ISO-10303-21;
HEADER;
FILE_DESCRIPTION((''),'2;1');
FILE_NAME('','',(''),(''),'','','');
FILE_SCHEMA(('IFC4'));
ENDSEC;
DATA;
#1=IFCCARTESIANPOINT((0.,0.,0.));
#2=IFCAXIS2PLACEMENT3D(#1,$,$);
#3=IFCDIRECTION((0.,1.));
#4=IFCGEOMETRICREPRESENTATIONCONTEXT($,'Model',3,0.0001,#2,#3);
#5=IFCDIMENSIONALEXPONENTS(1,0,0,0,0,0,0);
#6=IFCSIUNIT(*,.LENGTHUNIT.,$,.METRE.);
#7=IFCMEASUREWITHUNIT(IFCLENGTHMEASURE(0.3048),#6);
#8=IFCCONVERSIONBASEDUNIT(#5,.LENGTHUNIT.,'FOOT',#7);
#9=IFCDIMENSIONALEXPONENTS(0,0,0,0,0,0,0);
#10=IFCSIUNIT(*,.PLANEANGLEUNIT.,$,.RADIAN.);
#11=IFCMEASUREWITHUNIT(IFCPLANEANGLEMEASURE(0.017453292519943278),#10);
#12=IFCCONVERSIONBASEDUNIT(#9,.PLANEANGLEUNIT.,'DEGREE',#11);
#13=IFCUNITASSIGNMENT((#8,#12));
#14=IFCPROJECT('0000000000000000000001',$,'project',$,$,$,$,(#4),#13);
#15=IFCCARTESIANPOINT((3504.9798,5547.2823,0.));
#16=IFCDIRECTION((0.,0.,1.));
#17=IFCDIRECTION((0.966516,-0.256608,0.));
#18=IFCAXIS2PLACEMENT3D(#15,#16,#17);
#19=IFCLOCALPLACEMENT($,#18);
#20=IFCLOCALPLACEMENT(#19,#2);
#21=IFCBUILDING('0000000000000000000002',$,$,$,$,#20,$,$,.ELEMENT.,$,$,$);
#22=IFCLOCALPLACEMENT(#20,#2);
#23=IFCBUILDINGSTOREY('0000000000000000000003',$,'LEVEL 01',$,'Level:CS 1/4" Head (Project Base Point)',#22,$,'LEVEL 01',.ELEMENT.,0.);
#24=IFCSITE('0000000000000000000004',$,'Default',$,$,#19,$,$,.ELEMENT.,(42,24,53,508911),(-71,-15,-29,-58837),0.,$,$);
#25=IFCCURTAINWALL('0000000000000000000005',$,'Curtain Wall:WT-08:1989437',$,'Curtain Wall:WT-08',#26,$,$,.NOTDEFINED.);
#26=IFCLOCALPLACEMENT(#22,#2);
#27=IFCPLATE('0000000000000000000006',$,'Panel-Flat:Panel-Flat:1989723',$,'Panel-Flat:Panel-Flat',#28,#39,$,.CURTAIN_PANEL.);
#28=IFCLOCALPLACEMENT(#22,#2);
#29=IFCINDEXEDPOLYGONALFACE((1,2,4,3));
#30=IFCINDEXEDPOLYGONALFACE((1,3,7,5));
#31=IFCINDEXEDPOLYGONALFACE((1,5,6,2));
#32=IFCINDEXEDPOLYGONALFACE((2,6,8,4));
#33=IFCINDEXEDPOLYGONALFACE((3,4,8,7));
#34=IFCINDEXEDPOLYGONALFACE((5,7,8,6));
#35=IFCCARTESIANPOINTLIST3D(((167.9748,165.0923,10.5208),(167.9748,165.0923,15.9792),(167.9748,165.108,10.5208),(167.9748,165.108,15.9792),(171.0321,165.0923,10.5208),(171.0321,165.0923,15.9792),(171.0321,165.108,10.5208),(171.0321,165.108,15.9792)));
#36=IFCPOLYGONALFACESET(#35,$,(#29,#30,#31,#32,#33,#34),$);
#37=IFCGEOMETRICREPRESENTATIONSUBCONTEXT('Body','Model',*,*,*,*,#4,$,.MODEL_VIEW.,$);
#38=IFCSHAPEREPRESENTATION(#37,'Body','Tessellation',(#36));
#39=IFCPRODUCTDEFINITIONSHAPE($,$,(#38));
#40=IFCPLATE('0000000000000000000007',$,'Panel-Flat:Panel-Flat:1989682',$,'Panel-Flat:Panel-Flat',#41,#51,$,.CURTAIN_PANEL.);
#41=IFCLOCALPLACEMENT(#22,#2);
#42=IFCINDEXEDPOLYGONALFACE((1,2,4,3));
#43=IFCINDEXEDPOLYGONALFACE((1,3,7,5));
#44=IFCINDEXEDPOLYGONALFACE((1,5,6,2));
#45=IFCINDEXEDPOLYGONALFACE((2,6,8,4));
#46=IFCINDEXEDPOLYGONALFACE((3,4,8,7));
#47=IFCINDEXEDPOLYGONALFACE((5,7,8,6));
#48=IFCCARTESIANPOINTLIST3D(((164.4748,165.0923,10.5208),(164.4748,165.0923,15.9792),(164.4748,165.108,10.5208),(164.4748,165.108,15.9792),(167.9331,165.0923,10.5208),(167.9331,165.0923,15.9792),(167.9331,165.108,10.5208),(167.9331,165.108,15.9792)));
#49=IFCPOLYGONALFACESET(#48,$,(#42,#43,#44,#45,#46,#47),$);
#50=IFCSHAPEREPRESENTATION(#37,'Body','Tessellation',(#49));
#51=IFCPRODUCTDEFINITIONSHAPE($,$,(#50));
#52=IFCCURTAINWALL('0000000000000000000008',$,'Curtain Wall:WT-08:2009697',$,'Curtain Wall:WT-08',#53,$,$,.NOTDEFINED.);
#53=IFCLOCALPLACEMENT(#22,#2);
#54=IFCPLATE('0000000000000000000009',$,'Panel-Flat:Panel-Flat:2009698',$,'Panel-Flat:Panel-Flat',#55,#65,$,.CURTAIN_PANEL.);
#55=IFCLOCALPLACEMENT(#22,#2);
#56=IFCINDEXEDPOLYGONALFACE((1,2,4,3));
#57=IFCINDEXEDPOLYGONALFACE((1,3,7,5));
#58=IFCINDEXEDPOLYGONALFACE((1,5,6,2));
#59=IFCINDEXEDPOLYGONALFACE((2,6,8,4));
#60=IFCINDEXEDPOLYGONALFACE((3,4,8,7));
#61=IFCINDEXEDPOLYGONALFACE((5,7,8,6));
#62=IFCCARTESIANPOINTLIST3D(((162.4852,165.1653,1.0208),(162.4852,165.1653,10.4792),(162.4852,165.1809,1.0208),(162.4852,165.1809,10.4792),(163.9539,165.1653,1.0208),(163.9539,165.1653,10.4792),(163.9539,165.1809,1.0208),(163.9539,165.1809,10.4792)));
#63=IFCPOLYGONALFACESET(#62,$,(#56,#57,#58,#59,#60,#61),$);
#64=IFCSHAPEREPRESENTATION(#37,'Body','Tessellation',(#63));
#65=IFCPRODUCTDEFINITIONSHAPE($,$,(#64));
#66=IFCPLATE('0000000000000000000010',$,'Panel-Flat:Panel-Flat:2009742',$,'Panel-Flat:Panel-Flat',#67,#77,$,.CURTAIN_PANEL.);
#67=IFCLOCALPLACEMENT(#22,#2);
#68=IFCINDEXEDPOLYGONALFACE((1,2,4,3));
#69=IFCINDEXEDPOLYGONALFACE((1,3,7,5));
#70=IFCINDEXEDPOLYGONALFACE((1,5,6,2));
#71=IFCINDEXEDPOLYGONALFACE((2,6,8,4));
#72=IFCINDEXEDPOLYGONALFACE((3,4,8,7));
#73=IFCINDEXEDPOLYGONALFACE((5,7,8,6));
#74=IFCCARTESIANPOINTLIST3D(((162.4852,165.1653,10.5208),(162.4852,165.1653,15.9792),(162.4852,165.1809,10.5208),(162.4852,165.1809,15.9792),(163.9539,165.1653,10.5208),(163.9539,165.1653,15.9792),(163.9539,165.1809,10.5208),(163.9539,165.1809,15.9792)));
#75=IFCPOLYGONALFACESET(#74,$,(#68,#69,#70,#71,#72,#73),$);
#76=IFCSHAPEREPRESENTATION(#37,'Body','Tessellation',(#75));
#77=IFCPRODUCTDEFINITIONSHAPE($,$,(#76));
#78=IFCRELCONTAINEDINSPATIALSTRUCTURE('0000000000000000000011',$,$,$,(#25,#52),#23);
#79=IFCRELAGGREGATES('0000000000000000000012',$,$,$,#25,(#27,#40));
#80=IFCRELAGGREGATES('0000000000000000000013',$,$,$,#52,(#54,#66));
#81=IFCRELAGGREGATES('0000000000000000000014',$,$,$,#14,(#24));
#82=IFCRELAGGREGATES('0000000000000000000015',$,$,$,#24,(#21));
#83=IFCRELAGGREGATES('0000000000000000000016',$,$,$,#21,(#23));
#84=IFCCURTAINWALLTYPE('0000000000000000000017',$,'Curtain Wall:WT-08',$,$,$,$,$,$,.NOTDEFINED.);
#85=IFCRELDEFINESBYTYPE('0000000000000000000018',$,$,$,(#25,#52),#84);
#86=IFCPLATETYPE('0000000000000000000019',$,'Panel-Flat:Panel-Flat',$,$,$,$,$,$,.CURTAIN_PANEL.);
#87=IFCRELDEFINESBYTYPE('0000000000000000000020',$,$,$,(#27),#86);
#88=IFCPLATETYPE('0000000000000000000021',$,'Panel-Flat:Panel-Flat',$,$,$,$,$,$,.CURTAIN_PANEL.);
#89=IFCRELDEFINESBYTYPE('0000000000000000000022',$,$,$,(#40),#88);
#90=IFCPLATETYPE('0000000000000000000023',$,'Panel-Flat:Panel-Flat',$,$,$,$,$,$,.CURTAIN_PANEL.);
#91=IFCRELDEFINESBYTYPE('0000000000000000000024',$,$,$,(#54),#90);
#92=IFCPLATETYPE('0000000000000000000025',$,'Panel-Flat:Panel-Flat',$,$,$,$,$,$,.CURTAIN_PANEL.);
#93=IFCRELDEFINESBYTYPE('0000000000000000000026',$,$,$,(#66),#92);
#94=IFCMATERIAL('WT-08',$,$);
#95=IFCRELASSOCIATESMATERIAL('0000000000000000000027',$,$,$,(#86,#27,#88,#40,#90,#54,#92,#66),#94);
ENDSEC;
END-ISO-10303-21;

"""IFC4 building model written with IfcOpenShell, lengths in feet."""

from ifc_helpers import new_model, entity, si_unit, converted_unit, direction, frame, origin, place, context, subcontext, project, spatial, indexed_curve, outline, extrude, source, transform, mapped, material, type_object, type_shapes, element, aggregate, save


model = new_model("IFC4")

# Units and contexts
model_context = context("Model", 3, precision=0.0001, world=origin(), true_north=direction((0.0, 1.0)))
body_context = subcontext(model_context, "Body", "Model", "MODEL_VIEW")
ifc_project = project(units=[converted_unit("LENGTHUNIT", "FOOT", entity("IfcLengthMeasure", 0.3048), si_unit("LENGTHUNIT", "METRE"), dimensions=[1, 0, 0, 0, 0, 0, 0]), converted_unit("PLANEANGLEUNIT", "DEGREE", entity("IfcPlaneAngleMeasure", 0.017453292519943278), si_unit("PLANEANGLEUNIT", "RADIAN"), dimensions=[0, 0, 0, 0, 0, 0, 0])], contexts=[model_context])

# Site, building, storey
site_placement = place(None, frame((3504.9798, 5547.2823, 0.0), z_axis=(0.0, 0.0, 1.0), x_axis=(0.966516, -0.256608, 0.0)))
site = spatial("IfcSite", under=ifc_project, at=site_placement, Name="Default", CompositionType="ELEMENT", RefLatitude=(42, 24, 53, 508911), RefLongitude=(-71, -15, -29, -58837), RefElevation=0.0)
building_placement = place(site_placement, origin())
building = spatial("IfcBuilding", under=site, at=building_placement, CompositionType="ELEMENT")
storey_placement = place(building_placement, origin())
storey = spatial("IfcBuildingStorey", under=building, at=storey_placement, Name="LEVEL 01", ObjectType="Level:CS 1/4\" Head (Project Base Point)", LongName="LEVEL 01", CompositionType="ELEMENT", Elevation=0.0)

# Curtain wall, plates
curtain_wall_type_1 = type_object("IfcCurtainWallType", Name="Curtain Wall:WT-08", PredefinedType="NOTDEFINED")
curtain_wall_1_placement = place(storey_placement, origin())
curtain_wall_1 = element("IfcCurtainWall", 1, at=curtain_wall_1_placement, inside=storey, type_object=curtain_wall_type_1, Name="Curtain Wall:WT-08:1989437", ObjectType="Curtain Wall:WT-08", PredefinedType="NOTDEFINED")
ifc_material_1 = material(Name="WT-08")
plate_type_1 = type_object("IfcPlateType", Name="Panel-Flat:Panel-Flat", PredefinedType="CURTAIN_PANEL", material=ifc_material_1)
shared_shape_1 = source(origin(), body_context, "Body", "SweptSolid", [
    extrude(outline(indexed_curve([(-0.0078, -1.5287), (0.0078, -1.5287), (0.0078, 1.5287), (-0.0078, 1.5287), (-0.0078, -1.5287)], self_intersect=False)), frame((1.5287, 0.0078, 0.0), z_axis=(0.0, 0.0, 1.0), x_axis=(0.0, -1.0, 0.0)), (0.0, 0.0, 1.0), 5.4583),
])
type_shapes(plate_type_1, [shared_shape_1])
plate_1_placement = place(curtain_wall_1_placement, frame((171.0321, 165.108, 10.5208), z_axis=(0.0, 0.0, 1.0), x_axis=(-1.0, 0.0, 0.0)))
plate_1 = element("IfcPlate", 2, at=plate_1_placement, type_object=plate_type_1, material=ifc_material_1, Name="Panel-Flat:Panel-Flat:1989723", ObjectType="Panel-Flat:Panel-Flat", PredefinedType="CURTAIN_PANEL", context=body_context, shape_type="MappedRepresentation", body=[
    mapped(shared_shape_1, transform((0.0, 0.0, 0.0), scale=1.0)),
])
plate_type_2 = type_object("IfcPlateType", Name="Panel-Flat:Panel-Flat", PredefinedType="CURTAIN_PANEL", material=ifc_material_1)
shared_shape_2 = source(origin(), body_context, "Body", "SweptSolid", [
    extrude(outline(indexed_curve([(-0.0078, -1.7292), (0.0078, -1.7292), (0.0078, 1.7292), (-0.0078, 1.7292), (-0.0078, -1.7292)], self_intersect=False)), frame((1.7292, 0.0078, 0.0), z_axis=(0.0, 0.0, 1.0), x_axis=(0.0, -1.0, 0.0)), (0.0, 0.0, 1.0), 5.4583),
])
type_shapes(plate_type_2, [shared_shape_2])
plate_2_placement = place(curtain_wall_1_placement, frame((167.9331, 165.108, 10.5208), z_axis=(0.0, 0.0, 1.0), x_axis=(-1.0, 0.0, 0.0)))
plate_2 = element("IfcPlate", 3, at=plate_2_placement, type_object=plate_type_2, material=ifc_material_1, Name="Panel-Flat:Panel-Flat:1989682", ObjectType="Panel-Flat:Panel-Flat", PredefinedType="CURTAIN_PANEL", context=body_context, shape_type="MappedRepresentation", body=[
    mapped(shared_shape_2, transform((0.0, 0.0, 0.0), scale=1.0)),
])
aggregate(curtain_wall_1, [plate_1, plate_2])

# Curtain wall, plates
curtain_wall_2_placement = place(storey_placement, origin())
curtain_wall_2 = element("IfcCurtainWall", 4, at=curtain_wall_2_placement, inside=storey, type_object=curtain_wall_type_1, Name="Curtain Wall:WT-08:2009697", ObjectType="Curtain Wall:WT-08", PredefinedType="NOTDEFINED")
plate_type_3 = type_object("IfcPlateType", Name="Panel-Flat:Panel-Flat", PredefinedType="CURTAIN_PANEL", material=ifc_material_1)
shared_shape_3 = source(origin(), body_context, "Body", "SweptSolid", [
    extrude(outline(indexed_curve([(-0.0078, -0.7344), (0.0078, -0.7344), (0.0078, 0.7344), (-0.0078, 0.7344), (-0.0078, -0.7344)], self_intersect=False)), frame((0.7344, 0.0078, 0.0), z_axis=(0.0, 0.0, 1.0), x_axis=(0.0, -1.0, 0.0)), (0.0, 0.0, 1.0), 9.4583),
])
type_shapes(plate_type_3, [shared_shape_3])
plate_3_placement = place(curtain_wall_2_placement, frame((163.9539, 165.1809, 1.0208), z_axis=(0.0, 0.0, 1.0), x_axis=(-1.0, 0.0, 0.0)))
plate_3 = element("IfcPlate", 5, at=plate_3_placement, type_object=plate_type_3, material=ifc_material_1, Name="Panel-Flat:Panel-Flat:2009698", ObjectType="Panel-Flat:Panel-Flat", PredefinedType="CURTAIN_PANEL", context=body_context, shape_type="MappedRepresentation", body=[
    mapped(shared_shape_3, transform((0.0, 0.0, 0.0), scale=1.0)),
])
plate_type_4 = type_object("IfcPlateType", Name="Panel-Flat:Panel-Flat", PredefinedType="CURTAIN_PANEL", material=ifc_material_1)
shared_shape_4 = source(origin(), body_context, "Body", "SweptSolid", [
    extrude(outline(indexed_curve([(-0.0078, -0.7344), (0.0078, -0.7344), (0.0078, 0.7344), (-0.0078, 0.7344), (-0.0078, -0.7344)], self_intersect=False)), frame((0.7344, 0.0078, 0.0), z_axis=(0.0, 0.0, 1.0), x_axis=(0.0, -1.0, 0.0)), (0.0, 0.0, 1.0), 5.4583),
])
type_shapes(plate_type_4, [shared_shape_4])
plate_4_placement = place(curtain_wall_2_placement, frame((163.9539, 165.1809, 10.5208), z_axis=(0.0, 0.0, 1.0), x_axis=(-1.0, 0.0, 0.0)))
plate_4 = element("IfcPlate", 6, at=plate_4_placement, type_object=plate_type_4, material=ifc_material_1, Name="Panel-Flat:Panel-Flat:2009742", ObjectType="Panel-Flat:Panel-Flat", PredefinedType="CURTAIN_PANEL", context=body_context, shape_type="MappedRepresentation", body=[
    mapped(shared_shape_4, transform((0.0, 0.0, 0.0), scale=1.0)),
])
aggregate(curtain_wall_2, [plate_3, plate_4])

save(model, "model.ifc")
